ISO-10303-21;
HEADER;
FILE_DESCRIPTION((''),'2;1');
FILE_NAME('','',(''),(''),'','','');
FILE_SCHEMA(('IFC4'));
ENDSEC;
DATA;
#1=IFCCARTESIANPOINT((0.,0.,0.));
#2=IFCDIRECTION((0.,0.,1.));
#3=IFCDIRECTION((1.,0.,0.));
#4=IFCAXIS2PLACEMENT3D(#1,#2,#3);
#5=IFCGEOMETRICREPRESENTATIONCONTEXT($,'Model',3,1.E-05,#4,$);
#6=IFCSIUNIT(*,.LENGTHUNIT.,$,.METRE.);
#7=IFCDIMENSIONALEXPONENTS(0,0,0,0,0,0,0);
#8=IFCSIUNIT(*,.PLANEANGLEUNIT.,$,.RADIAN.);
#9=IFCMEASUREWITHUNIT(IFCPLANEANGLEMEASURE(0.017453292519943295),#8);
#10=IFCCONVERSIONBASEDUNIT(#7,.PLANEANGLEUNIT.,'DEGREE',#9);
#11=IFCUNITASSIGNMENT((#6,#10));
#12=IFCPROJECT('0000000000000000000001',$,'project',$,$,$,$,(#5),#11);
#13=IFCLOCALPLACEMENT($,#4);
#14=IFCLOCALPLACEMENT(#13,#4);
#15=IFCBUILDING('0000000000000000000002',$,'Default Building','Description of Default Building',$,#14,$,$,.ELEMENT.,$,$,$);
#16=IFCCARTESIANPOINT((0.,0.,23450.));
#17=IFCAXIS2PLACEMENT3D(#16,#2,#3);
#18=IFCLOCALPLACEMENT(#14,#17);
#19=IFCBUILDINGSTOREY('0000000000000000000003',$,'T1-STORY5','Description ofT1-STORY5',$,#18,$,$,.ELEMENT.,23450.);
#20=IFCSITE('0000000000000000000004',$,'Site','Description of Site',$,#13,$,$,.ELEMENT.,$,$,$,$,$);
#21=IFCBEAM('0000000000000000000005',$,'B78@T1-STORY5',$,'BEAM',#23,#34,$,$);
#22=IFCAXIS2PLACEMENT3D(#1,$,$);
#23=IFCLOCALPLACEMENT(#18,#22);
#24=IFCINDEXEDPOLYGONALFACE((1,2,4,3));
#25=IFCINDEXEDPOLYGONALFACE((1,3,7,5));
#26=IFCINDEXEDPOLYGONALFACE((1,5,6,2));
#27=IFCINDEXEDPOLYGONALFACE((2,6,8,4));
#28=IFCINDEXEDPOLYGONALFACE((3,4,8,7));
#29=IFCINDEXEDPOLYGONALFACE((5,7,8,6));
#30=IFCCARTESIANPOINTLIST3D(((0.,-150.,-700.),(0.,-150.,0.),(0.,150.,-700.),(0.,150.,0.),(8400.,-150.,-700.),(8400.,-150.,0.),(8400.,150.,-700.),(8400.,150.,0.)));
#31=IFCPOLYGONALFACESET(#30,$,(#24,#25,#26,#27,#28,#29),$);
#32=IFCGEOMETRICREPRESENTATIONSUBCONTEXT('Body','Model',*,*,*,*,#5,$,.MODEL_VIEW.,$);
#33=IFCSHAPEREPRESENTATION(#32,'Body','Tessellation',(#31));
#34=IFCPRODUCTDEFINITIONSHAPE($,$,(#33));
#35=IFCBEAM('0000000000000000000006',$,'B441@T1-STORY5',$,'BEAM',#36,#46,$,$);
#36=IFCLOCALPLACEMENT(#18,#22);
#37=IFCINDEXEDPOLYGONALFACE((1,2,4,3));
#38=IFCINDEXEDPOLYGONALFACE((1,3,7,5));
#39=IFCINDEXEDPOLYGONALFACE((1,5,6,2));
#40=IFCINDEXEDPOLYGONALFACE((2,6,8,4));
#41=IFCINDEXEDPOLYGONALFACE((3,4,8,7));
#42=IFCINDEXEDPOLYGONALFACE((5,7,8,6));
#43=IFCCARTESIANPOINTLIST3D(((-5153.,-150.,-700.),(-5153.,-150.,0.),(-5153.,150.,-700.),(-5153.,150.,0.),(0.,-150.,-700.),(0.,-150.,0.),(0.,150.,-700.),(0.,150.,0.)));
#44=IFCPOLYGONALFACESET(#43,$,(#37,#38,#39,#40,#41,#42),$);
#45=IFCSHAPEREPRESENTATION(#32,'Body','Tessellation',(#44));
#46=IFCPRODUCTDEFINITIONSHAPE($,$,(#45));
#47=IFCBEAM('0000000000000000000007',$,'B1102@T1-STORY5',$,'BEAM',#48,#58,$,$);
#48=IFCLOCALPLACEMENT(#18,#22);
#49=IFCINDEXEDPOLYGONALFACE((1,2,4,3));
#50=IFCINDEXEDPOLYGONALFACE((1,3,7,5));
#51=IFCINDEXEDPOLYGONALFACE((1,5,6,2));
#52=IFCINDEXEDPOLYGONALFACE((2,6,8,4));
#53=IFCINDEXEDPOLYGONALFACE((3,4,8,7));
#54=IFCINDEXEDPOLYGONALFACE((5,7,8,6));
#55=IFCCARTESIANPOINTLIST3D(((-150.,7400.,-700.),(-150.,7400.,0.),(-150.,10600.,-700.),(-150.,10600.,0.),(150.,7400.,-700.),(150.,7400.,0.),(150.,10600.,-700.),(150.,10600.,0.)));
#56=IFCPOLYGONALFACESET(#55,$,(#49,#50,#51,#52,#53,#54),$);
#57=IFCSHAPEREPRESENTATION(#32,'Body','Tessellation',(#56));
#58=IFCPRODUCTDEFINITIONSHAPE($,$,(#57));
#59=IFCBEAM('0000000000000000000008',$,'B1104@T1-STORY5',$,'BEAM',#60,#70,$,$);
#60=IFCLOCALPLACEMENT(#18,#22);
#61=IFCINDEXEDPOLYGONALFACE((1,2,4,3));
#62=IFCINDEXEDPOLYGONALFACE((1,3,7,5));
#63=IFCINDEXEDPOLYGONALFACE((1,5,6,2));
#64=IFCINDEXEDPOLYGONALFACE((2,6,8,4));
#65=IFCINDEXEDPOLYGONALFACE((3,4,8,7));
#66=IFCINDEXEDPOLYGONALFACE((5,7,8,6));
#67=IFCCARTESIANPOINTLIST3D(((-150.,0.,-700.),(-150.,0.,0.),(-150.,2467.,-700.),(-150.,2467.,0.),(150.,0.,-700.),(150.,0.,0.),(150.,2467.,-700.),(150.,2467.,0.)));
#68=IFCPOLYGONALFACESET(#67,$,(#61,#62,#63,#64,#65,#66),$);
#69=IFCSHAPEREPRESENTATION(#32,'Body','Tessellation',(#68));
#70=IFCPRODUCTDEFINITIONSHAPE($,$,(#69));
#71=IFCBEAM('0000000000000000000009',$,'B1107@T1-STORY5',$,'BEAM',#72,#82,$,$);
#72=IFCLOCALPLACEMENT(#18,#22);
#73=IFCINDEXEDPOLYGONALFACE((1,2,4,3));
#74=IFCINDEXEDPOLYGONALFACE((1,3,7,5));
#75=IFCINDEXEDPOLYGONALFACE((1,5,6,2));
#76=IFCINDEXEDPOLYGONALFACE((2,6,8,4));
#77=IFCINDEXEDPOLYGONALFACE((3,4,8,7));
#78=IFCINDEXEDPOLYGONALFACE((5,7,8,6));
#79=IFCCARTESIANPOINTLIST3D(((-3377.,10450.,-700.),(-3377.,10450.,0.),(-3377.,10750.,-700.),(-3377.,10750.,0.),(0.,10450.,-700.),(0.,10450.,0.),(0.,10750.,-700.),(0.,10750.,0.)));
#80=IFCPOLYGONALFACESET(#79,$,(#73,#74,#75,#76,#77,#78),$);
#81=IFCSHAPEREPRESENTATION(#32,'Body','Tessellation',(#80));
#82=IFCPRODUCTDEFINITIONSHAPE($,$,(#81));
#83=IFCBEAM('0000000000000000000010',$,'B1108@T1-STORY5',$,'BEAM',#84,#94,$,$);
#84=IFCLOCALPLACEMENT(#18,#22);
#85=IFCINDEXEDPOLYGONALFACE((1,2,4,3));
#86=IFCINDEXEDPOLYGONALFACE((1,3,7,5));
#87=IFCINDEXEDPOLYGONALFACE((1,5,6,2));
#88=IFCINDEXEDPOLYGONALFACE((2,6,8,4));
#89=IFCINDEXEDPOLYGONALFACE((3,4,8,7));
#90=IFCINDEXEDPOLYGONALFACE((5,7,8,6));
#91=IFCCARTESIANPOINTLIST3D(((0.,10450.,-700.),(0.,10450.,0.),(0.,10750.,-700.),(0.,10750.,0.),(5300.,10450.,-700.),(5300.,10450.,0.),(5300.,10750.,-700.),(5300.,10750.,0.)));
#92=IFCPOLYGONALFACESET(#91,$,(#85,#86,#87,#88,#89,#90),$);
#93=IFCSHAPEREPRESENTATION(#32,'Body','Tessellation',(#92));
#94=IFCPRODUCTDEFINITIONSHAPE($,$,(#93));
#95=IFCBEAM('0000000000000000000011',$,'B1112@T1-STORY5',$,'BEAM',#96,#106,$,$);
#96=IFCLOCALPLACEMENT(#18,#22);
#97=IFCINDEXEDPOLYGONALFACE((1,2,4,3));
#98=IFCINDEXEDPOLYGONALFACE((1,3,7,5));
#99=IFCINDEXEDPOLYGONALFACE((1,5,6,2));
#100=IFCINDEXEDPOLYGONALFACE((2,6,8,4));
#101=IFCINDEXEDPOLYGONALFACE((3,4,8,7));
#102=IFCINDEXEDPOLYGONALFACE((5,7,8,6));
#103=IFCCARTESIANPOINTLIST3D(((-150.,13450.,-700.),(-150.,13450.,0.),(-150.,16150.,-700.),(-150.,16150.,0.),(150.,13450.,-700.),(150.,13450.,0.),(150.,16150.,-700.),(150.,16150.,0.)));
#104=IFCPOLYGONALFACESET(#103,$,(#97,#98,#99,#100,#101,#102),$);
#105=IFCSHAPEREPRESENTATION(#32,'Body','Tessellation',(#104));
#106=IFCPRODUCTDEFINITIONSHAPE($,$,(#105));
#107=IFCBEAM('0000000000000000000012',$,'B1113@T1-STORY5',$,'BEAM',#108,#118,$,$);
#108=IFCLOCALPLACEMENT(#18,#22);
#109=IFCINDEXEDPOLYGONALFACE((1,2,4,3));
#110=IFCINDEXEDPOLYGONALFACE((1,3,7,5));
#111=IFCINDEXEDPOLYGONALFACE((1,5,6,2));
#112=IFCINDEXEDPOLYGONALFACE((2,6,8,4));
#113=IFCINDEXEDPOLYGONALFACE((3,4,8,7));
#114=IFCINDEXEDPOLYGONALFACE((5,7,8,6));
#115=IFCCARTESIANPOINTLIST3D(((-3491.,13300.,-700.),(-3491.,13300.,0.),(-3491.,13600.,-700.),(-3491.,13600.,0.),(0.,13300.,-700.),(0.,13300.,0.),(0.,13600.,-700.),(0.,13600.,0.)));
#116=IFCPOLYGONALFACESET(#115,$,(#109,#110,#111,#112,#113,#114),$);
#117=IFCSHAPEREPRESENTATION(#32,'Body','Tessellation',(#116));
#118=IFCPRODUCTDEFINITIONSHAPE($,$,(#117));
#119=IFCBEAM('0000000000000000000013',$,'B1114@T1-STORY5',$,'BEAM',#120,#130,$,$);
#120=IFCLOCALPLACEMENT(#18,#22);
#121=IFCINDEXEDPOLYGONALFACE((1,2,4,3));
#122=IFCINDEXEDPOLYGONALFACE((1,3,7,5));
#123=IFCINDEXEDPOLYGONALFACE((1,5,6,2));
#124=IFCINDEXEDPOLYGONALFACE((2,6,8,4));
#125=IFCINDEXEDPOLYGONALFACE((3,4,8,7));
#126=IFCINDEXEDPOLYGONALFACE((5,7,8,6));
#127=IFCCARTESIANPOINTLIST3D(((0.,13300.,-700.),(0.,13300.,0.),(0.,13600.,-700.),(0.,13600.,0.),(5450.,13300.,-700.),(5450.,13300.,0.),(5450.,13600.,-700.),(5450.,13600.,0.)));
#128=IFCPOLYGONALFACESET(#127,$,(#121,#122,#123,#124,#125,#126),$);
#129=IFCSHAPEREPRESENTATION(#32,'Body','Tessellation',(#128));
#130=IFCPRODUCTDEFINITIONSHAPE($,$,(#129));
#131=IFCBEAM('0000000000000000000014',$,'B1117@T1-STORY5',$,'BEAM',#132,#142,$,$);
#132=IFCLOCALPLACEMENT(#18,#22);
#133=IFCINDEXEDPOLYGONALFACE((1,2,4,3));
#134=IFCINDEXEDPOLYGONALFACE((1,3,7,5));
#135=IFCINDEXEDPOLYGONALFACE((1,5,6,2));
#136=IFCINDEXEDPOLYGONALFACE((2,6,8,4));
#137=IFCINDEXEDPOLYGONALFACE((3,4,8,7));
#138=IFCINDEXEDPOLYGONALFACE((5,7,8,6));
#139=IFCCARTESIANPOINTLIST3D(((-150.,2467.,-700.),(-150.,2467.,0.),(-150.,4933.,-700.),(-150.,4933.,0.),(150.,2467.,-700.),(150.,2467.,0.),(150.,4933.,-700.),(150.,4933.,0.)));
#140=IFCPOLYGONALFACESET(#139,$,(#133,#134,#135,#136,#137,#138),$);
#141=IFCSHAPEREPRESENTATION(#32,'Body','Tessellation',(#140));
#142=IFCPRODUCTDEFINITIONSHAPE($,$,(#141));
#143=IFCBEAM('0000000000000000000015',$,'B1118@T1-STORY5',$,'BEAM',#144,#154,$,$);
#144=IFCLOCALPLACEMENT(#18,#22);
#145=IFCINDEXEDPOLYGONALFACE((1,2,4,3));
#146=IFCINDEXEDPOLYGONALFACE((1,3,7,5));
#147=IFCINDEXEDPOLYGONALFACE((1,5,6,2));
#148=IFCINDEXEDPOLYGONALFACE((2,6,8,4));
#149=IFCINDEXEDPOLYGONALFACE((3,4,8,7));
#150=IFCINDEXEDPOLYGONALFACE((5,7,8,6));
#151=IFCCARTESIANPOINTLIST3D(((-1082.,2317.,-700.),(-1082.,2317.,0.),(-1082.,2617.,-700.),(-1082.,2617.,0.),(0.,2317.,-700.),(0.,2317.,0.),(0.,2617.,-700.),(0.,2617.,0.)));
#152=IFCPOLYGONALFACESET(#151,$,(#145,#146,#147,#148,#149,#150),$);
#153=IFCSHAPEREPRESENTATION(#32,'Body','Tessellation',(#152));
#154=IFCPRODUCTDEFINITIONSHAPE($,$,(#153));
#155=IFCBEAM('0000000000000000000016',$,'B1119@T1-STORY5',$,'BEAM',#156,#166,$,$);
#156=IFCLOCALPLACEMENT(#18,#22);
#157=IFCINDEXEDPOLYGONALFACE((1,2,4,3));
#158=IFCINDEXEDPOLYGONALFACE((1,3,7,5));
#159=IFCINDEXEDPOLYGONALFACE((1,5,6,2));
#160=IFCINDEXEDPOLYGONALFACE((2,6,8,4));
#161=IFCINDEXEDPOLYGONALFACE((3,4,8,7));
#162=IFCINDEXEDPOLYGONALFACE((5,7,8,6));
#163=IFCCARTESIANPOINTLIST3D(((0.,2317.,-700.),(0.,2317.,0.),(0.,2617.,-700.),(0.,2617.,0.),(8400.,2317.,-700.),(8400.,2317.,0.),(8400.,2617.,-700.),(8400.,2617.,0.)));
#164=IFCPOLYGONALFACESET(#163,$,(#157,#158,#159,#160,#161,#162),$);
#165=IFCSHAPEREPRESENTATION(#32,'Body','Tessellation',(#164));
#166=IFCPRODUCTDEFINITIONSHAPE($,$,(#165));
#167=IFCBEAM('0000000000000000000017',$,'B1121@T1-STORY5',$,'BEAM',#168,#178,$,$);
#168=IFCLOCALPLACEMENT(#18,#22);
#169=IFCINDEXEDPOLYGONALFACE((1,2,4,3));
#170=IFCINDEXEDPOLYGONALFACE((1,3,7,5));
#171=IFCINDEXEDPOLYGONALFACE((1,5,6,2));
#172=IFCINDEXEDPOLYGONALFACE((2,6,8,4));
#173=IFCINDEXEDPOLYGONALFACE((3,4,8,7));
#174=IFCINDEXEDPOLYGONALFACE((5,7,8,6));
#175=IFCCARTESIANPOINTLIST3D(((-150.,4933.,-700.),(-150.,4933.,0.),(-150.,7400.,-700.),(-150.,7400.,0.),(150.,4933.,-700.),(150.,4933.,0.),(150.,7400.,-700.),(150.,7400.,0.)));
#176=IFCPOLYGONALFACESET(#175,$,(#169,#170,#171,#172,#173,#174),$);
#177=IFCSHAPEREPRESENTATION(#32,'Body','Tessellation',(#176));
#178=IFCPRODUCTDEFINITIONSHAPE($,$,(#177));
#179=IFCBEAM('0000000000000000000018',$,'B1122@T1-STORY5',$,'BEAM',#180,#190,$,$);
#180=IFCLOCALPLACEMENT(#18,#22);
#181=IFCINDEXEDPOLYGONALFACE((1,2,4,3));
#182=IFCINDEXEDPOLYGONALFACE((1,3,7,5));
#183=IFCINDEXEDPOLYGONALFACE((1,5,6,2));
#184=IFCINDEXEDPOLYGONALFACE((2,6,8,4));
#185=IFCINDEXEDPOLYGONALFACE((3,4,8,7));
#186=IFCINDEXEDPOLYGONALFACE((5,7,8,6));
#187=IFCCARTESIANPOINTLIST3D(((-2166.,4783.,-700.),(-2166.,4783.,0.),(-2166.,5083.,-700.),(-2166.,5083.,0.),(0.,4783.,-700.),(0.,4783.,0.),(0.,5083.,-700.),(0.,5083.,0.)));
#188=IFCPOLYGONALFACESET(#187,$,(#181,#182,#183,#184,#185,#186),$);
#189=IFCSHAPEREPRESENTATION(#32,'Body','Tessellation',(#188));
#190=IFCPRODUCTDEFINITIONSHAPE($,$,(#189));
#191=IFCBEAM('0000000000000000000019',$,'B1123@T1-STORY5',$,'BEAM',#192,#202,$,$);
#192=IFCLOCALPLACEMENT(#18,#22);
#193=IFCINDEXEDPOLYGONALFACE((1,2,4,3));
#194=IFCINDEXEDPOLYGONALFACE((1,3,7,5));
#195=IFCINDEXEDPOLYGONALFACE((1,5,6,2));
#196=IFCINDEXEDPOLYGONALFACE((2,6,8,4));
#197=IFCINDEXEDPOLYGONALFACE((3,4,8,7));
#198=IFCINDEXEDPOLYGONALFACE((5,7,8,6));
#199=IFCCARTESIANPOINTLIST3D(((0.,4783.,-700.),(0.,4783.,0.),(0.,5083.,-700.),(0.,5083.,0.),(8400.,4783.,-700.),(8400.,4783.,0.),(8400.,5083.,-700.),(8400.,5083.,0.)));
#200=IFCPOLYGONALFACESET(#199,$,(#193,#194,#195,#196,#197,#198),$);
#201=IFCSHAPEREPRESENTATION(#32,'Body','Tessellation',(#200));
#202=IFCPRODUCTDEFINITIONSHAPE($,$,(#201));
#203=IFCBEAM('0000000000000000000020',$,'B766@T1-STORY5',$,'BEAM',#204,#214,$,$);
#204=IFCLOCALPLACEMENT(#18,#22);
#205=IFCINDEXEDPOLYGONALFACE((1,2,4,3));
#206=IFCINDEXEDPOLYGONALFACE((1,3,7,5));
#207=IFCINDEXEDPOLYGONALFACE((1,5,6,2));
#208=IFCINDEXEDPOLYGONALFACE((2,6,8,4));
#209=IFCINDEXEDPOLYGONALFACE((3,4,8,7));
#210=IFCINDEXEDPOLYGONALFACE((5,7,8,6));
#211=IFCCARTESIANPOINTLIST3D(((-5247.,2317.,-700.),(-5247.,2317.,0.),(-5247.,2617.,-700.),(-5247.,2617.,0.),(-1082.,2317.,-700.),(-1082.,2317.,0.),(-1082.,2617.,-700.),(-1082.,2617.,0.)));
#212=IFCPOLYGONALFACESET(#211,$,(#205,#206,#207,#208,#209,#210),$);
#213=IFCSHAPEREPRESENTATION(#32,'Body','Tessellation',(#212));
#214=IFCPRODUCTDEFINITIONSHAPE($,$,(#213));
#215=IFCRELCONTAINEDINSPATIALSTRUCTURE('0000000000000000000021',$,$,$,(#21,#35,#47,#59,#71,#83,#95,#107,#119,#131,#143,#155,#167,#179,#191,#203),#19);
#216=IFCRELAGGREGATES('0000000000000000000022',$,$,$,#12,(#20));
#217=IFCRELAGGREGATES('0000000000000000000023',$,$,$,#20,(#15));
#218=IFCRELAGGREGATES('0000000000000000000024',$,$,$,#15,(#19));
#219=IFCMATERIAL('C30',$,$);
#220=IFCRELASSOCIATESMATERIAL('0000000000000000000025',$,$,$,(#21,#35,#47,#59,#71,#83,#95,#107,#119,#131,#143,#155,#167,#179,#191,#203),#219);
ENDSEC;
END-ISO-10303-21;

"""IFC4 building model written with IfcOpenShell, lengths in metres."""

from ifc_helpers import new_model, entity, si_unit, converted_unit, frame, origin_with_axes, place, context, subcontext, project, spatial, rectangle, extrude, material, element, save


model = new_model("IFC4")

# Units and contexts
model_context = context("Model", 3, precision=1e-05, world=origin_with_axes())
body_context = subcontext(model_context, "Body", "Model", "MODEL_VIEW")
ifc_project = project(units=[si_unit("LENGTHUNIT", "METRE"), converted_unit("PLANEANGLEUNIT", "DEGREE", entity("IfcPlaneAngleMeasure", 0.017453292519943295), si_unit("PLANEANGLEUNIT", "RADIAN"), dimensions=[0, 0, 0, 0, 0, 0, 0])], contexts=[model_context])

# Site, building, storey
site_placement = place(None, origin_with_axes())
site = spatial("IfcSite", under=ifc_project, at=site_placement, Name="Site", Description="Description of Site", CompositionType="ELEMENT")
building_placement = place(site_placement, origin_with_axes())
building = spatial("IfcBuilding", under=site, at=building_placement, Name="Default Building", Description="Description of Default Building", CompositionType="ELEMENT")
storey_placement = place(building_placement, frame((0.0, 0.0, 23450.0), z_axis=(0.0, 0.0, 1.0), x_axis=(1.0, 0.0, 0.0)))
storey = spatial("IfcBuildingStorey", under=building, at=storey_placement, Name="T1-STORY5", Description="Description ofT1-STORY5", CompositionType="ELEMENT", Elevation=23450.0)

# Beams
ifc_material_1 = material(Name="C30")
beam_1_placement = place(storey_placement, frame((0.0, 0.0, -350.0), z_axis=(1.0, 0.0, 0.0), x_axis=(0.0, 1.0, 0.0)))
element("IfcBeam", 1, at=beam_1_placement, inside=storey, material=ifc_material_1, Name="B78@T1-STORY5", ObjectType="BEAM", context=body_context, shape_type="SweptSolid", body=[
    extrude(rectangle(XDim=300.0, YDim=700.0), origin_with_axes(), (0.0, 0.0, 1.0), 8400.0),
])
beam_2_placement = place(storey_placement, frame((-5153.0, 0.0, -350.0), z_axis=(1.0, 0.0, 0.0), x_axis=(0.0, 1.0, 0.0)))
element("IfcBeam", 2, at=beam_2_placement, inside=storey, material=ifc_material_1, Name="B441@T1-STORY5", ObjectType="BEAM", context=body_context, shape_type="SweptSolid", body=[
    extrude(rectangle(XDim=300.0, YDim=700.0), origin_with_axes(), (0.0, 0.0, 1.0), 5153.0),
])
beam_3_placement = place(storey_placement, frame((0.0, 7400.0, -350.0), z_axis=(0.0, 1.0, 0.0), x_axis=(-1.0, 0.0, 0.0)))
element("IfcBeam", 3, at=beam_3_placement, inside=storey, material=ifc_material_1, Name="B1102@T1-STORY5", ObjectType="BEAM", context=body_context, shape_type="SweptSolid", body=[
    extrude(rectangle(XDim=300.0, YDim=700.0), origin_with_axes(), (0.0, 0.0, 1.0), 3200.0),
])
beam_4_placement = place(storey_placement, frame((0.0, 0.0, -350.0), z_axis=(0.0, 1.0, 0.0), x_axis=(-1.0, 0.0, 0.0)))
element("IfcBeam", 4, at=beam_4_placement, inside=storey, material=ifc_material_1, Name="B1104@T1-STORY5", ObjectType="BEAM", context=body_context, shape_type="SweptSolid", body=[
    extrude(rectangle(XDim=300.0, YDim=700.0), origin_with_axes(), (0.0, 0.0, 1.0), 2467.0),
])
beam_5_placement = place(storey_placement, frame((-3377.0, 10600.0, -350.0), z_axis=(1.0, 0.0, 0.0), x_axis=(0.0, 1.0, 0.0)))
element("IfcBeam", 5, at=beam_5_placement, inside=storey, material=ifc_material_1, Name="B1107@T1-STORY5", ObjectType="BEAM", context=body_context, shape_type="SweptSolid", body=[
    extrude(rectangle(XDim=300.0, YDim=700.0), origin_with_axes(), (0.0, 0.0, 1.0), 3377.0),
])
beam_6_placement = place(storey_placement, frame((0.0, 10600.0, -350.0), z_axis=(1.0, 0.0, 0.0), x_axis=(0.0, 1.0, 0.0)))
element("IfcBeam", 6, at=beam_6_placement, inside=storey, material=ifc_material_1, Name="B1108@T1-STORY5", ObjectType="BEAM", context=body_context, shape_type="SweptSolid", body=[
    extrude(rectangle(XDim=300.0, YDim=700.0), origin_with_axes(), (0.0, 0.0, 1.0), 5300.0),
])
beam_7_placement = place(storey_placement, frame((0.0, 13450.0, -350.0), z_axis=(0.0, 1.0, 0.0), x_axis=(-1.0, 0.0, 0.0)))
element("IfcBeam", 7, at=beam_7_placement, inside=storey, material=ifc_material_1, Name="B1112@T1-STORY5", ObjectType="BEAM", context=body_context, shape_type="SweptSolid", body=[
    extrude(rectangle(XDim=300.0, YDim=700.0), origin_with_axes(), (0.0, 0.0, 1.0), 2700.0),
])
beam_8_placement = place(storey_placement, frame((-3491.0, 13450.0, -350.0), z_axis=(1.0, 0.0, 0.0), x_axis=(0.0, 1.0, 0.0)))
element("IfcBeam", 8, at=beam_8_placement, inside=storey, material=ifc_material_1, Name="B1113@T1-STORY5", ObjectType="BEAM", context=body_context, shape_type="SweptSolid", body=[
    extrude(rectangle(XDim=300.0, YDim=700.0), origin_with_axes(), (0.0, 0.0, 1.0), 3491.0),
])
beam_9_placement = place(storey_placement, frame((0.0, 13450.0, -350.0), z_axis=(1.0, 0.0, 0.0), x_axis=(0.0, 1.0, 0.0)))
element("IfcBeam", 9, at=beam_9_placement, inside=storey, material=ifc_material_1, Name="B1114@T1-STORY5", ObjectType="BEAM", context=body_context, shape_type="SweptSolid", body=[
    extrude(rectangle(XDim=300.0, YDim=700.0), origin_with_axes(), (0.0, 0.0, 1.0), 5450.0),
])
beam_10_placement = place(storey_placement, frame((0.0, 2467.0, -350.0), z_axis=(0.0, 1.0, 0.0), x_axis=(-1.0, 0.0, 0.0)))
element("IfcBeam", 10, at=beam_10_placement, inside=storey, material=ifc_material_1, Name="B1117@T1-STORY5", ObjectType="BEAM", context=body_context, shape_type="SweptSolid", body=[
    extrude(rectangle(XDim=300.0, YDim=700.0), origin_with_axes(), (0.0, 0.0, 1.0), 2466.0),
])
beam_11_placement = place(storey_placement, frame((-1082.0, 2467.0, -350.0), z_axis=(1.0, 0.0, 0.0), x_axis=(0.0, 1.0, 0.0)))
element("IfcBeam", 11, at=beam_11_placement, inside=storey, material=ifc_material_1, Name="B1118@T1-STORY5", ObjectType="BEAM", context=body_context, shape_type="SweptSolid", body=[
    extrude(rectangle(XDim=300.0, YDim=700.0), origin_with_axes(), (0.0, 0.0, 1.0), 1082.0),
])
beam_12_placement = place(storey_placement, frame((0.0, 2467.0, -350.0), z_axis=(1.0, 0.0, 0.0), x_axis=(0.0, 1.0, 0.0)))
element("IfcBeam", 12, at=beam_12_placement, inside=storey, material=ifc_material_1, Name="B1119@T1-STORY5", ObjectType="BEAM", context=body_context, shape_type="SweptSolid", body=[
    extrude(rectangle(XDim=300.0, YDim=700.0), origin_with_axes(), (0.0, 0.0, 1.0), 8400.0),
])
beam_13_placement = place(storey_placement, frame((0.0, 4933.0, -350.0), z_axis=(0.0, 1.0, 0.0), x_axis=(-1.0, 0.0, 0.0)))
element("IfcBeam", 13, at=beam_13_placement, inside=storey, material=ifc_material_1, Name="B1121@T1-STORY5", ObjectType="BEAM", context=body_context, shape_type="SweptSolid", body=[
    extrude(rectangle(XDim=300.0, YDim=700.0), origin_with_axes(), (0.0, 0.0, 1.0), 2467.0),
])
beam_14_placement = place(storey_placement, frame((-2166.0, 4933.0, -350.0), z_axis=(1.0, 0.0, 0.0), x_axis=(0.0, 1.0, 0.0)))
element("IfcBeam", 14, at=beam_14_placement, inside=storey, material=ifc_material_1, Name="B1122@T1-STORY5", ObjectType="BEAM", context=body_context, shape_type="SweptSolid", body=[
    extrude(rectangle(XDim=300.0, YDim=700.0), origin_with_axes(), (0.0, 0.0, 1.0), 2166.0),
])
beam_15_placement = place(storey_placement, frame((0.0, 4933.0, -350.0), z_axis=(1.0, 0.0, 0.0), x_axis=(0.0, 1.0, 0.0)))
element("IfcBeam", 15, at=beam_15_placement, inside=storey, material=ifc_material_1, Name="B1123@T1-STORY5", ObjectType="BEAM", context=body_context, shape_type="SweptSolid", body=[
    extrude(rectangle(XDim=300.0, YDim=700.0), origin_with_axes(), (0.0, 0.0, 1.0), 8400.0),
])
beam_16_placement = place(storey_placement, frame((-5247.0, 2467.0, -350.0), z_axis=(1.0, 0.0, 0.0), x_axis=(0.0, 1.0, 0.0)))
element("IfcBeam", 16, at=beam_16_placement, inside=storey, material=ifc_material_1, Name="B766@T1-STORY5", ObjectType="BEAM", context=body_context, shape_type="SweptSolid", body=[
    extrude(rectangle(XDim=300.0, YDim=700.0), origin_with_axes(), (0.0, 0.0, 1.0), 4165.0),
])

save(model, "model.ifc")
